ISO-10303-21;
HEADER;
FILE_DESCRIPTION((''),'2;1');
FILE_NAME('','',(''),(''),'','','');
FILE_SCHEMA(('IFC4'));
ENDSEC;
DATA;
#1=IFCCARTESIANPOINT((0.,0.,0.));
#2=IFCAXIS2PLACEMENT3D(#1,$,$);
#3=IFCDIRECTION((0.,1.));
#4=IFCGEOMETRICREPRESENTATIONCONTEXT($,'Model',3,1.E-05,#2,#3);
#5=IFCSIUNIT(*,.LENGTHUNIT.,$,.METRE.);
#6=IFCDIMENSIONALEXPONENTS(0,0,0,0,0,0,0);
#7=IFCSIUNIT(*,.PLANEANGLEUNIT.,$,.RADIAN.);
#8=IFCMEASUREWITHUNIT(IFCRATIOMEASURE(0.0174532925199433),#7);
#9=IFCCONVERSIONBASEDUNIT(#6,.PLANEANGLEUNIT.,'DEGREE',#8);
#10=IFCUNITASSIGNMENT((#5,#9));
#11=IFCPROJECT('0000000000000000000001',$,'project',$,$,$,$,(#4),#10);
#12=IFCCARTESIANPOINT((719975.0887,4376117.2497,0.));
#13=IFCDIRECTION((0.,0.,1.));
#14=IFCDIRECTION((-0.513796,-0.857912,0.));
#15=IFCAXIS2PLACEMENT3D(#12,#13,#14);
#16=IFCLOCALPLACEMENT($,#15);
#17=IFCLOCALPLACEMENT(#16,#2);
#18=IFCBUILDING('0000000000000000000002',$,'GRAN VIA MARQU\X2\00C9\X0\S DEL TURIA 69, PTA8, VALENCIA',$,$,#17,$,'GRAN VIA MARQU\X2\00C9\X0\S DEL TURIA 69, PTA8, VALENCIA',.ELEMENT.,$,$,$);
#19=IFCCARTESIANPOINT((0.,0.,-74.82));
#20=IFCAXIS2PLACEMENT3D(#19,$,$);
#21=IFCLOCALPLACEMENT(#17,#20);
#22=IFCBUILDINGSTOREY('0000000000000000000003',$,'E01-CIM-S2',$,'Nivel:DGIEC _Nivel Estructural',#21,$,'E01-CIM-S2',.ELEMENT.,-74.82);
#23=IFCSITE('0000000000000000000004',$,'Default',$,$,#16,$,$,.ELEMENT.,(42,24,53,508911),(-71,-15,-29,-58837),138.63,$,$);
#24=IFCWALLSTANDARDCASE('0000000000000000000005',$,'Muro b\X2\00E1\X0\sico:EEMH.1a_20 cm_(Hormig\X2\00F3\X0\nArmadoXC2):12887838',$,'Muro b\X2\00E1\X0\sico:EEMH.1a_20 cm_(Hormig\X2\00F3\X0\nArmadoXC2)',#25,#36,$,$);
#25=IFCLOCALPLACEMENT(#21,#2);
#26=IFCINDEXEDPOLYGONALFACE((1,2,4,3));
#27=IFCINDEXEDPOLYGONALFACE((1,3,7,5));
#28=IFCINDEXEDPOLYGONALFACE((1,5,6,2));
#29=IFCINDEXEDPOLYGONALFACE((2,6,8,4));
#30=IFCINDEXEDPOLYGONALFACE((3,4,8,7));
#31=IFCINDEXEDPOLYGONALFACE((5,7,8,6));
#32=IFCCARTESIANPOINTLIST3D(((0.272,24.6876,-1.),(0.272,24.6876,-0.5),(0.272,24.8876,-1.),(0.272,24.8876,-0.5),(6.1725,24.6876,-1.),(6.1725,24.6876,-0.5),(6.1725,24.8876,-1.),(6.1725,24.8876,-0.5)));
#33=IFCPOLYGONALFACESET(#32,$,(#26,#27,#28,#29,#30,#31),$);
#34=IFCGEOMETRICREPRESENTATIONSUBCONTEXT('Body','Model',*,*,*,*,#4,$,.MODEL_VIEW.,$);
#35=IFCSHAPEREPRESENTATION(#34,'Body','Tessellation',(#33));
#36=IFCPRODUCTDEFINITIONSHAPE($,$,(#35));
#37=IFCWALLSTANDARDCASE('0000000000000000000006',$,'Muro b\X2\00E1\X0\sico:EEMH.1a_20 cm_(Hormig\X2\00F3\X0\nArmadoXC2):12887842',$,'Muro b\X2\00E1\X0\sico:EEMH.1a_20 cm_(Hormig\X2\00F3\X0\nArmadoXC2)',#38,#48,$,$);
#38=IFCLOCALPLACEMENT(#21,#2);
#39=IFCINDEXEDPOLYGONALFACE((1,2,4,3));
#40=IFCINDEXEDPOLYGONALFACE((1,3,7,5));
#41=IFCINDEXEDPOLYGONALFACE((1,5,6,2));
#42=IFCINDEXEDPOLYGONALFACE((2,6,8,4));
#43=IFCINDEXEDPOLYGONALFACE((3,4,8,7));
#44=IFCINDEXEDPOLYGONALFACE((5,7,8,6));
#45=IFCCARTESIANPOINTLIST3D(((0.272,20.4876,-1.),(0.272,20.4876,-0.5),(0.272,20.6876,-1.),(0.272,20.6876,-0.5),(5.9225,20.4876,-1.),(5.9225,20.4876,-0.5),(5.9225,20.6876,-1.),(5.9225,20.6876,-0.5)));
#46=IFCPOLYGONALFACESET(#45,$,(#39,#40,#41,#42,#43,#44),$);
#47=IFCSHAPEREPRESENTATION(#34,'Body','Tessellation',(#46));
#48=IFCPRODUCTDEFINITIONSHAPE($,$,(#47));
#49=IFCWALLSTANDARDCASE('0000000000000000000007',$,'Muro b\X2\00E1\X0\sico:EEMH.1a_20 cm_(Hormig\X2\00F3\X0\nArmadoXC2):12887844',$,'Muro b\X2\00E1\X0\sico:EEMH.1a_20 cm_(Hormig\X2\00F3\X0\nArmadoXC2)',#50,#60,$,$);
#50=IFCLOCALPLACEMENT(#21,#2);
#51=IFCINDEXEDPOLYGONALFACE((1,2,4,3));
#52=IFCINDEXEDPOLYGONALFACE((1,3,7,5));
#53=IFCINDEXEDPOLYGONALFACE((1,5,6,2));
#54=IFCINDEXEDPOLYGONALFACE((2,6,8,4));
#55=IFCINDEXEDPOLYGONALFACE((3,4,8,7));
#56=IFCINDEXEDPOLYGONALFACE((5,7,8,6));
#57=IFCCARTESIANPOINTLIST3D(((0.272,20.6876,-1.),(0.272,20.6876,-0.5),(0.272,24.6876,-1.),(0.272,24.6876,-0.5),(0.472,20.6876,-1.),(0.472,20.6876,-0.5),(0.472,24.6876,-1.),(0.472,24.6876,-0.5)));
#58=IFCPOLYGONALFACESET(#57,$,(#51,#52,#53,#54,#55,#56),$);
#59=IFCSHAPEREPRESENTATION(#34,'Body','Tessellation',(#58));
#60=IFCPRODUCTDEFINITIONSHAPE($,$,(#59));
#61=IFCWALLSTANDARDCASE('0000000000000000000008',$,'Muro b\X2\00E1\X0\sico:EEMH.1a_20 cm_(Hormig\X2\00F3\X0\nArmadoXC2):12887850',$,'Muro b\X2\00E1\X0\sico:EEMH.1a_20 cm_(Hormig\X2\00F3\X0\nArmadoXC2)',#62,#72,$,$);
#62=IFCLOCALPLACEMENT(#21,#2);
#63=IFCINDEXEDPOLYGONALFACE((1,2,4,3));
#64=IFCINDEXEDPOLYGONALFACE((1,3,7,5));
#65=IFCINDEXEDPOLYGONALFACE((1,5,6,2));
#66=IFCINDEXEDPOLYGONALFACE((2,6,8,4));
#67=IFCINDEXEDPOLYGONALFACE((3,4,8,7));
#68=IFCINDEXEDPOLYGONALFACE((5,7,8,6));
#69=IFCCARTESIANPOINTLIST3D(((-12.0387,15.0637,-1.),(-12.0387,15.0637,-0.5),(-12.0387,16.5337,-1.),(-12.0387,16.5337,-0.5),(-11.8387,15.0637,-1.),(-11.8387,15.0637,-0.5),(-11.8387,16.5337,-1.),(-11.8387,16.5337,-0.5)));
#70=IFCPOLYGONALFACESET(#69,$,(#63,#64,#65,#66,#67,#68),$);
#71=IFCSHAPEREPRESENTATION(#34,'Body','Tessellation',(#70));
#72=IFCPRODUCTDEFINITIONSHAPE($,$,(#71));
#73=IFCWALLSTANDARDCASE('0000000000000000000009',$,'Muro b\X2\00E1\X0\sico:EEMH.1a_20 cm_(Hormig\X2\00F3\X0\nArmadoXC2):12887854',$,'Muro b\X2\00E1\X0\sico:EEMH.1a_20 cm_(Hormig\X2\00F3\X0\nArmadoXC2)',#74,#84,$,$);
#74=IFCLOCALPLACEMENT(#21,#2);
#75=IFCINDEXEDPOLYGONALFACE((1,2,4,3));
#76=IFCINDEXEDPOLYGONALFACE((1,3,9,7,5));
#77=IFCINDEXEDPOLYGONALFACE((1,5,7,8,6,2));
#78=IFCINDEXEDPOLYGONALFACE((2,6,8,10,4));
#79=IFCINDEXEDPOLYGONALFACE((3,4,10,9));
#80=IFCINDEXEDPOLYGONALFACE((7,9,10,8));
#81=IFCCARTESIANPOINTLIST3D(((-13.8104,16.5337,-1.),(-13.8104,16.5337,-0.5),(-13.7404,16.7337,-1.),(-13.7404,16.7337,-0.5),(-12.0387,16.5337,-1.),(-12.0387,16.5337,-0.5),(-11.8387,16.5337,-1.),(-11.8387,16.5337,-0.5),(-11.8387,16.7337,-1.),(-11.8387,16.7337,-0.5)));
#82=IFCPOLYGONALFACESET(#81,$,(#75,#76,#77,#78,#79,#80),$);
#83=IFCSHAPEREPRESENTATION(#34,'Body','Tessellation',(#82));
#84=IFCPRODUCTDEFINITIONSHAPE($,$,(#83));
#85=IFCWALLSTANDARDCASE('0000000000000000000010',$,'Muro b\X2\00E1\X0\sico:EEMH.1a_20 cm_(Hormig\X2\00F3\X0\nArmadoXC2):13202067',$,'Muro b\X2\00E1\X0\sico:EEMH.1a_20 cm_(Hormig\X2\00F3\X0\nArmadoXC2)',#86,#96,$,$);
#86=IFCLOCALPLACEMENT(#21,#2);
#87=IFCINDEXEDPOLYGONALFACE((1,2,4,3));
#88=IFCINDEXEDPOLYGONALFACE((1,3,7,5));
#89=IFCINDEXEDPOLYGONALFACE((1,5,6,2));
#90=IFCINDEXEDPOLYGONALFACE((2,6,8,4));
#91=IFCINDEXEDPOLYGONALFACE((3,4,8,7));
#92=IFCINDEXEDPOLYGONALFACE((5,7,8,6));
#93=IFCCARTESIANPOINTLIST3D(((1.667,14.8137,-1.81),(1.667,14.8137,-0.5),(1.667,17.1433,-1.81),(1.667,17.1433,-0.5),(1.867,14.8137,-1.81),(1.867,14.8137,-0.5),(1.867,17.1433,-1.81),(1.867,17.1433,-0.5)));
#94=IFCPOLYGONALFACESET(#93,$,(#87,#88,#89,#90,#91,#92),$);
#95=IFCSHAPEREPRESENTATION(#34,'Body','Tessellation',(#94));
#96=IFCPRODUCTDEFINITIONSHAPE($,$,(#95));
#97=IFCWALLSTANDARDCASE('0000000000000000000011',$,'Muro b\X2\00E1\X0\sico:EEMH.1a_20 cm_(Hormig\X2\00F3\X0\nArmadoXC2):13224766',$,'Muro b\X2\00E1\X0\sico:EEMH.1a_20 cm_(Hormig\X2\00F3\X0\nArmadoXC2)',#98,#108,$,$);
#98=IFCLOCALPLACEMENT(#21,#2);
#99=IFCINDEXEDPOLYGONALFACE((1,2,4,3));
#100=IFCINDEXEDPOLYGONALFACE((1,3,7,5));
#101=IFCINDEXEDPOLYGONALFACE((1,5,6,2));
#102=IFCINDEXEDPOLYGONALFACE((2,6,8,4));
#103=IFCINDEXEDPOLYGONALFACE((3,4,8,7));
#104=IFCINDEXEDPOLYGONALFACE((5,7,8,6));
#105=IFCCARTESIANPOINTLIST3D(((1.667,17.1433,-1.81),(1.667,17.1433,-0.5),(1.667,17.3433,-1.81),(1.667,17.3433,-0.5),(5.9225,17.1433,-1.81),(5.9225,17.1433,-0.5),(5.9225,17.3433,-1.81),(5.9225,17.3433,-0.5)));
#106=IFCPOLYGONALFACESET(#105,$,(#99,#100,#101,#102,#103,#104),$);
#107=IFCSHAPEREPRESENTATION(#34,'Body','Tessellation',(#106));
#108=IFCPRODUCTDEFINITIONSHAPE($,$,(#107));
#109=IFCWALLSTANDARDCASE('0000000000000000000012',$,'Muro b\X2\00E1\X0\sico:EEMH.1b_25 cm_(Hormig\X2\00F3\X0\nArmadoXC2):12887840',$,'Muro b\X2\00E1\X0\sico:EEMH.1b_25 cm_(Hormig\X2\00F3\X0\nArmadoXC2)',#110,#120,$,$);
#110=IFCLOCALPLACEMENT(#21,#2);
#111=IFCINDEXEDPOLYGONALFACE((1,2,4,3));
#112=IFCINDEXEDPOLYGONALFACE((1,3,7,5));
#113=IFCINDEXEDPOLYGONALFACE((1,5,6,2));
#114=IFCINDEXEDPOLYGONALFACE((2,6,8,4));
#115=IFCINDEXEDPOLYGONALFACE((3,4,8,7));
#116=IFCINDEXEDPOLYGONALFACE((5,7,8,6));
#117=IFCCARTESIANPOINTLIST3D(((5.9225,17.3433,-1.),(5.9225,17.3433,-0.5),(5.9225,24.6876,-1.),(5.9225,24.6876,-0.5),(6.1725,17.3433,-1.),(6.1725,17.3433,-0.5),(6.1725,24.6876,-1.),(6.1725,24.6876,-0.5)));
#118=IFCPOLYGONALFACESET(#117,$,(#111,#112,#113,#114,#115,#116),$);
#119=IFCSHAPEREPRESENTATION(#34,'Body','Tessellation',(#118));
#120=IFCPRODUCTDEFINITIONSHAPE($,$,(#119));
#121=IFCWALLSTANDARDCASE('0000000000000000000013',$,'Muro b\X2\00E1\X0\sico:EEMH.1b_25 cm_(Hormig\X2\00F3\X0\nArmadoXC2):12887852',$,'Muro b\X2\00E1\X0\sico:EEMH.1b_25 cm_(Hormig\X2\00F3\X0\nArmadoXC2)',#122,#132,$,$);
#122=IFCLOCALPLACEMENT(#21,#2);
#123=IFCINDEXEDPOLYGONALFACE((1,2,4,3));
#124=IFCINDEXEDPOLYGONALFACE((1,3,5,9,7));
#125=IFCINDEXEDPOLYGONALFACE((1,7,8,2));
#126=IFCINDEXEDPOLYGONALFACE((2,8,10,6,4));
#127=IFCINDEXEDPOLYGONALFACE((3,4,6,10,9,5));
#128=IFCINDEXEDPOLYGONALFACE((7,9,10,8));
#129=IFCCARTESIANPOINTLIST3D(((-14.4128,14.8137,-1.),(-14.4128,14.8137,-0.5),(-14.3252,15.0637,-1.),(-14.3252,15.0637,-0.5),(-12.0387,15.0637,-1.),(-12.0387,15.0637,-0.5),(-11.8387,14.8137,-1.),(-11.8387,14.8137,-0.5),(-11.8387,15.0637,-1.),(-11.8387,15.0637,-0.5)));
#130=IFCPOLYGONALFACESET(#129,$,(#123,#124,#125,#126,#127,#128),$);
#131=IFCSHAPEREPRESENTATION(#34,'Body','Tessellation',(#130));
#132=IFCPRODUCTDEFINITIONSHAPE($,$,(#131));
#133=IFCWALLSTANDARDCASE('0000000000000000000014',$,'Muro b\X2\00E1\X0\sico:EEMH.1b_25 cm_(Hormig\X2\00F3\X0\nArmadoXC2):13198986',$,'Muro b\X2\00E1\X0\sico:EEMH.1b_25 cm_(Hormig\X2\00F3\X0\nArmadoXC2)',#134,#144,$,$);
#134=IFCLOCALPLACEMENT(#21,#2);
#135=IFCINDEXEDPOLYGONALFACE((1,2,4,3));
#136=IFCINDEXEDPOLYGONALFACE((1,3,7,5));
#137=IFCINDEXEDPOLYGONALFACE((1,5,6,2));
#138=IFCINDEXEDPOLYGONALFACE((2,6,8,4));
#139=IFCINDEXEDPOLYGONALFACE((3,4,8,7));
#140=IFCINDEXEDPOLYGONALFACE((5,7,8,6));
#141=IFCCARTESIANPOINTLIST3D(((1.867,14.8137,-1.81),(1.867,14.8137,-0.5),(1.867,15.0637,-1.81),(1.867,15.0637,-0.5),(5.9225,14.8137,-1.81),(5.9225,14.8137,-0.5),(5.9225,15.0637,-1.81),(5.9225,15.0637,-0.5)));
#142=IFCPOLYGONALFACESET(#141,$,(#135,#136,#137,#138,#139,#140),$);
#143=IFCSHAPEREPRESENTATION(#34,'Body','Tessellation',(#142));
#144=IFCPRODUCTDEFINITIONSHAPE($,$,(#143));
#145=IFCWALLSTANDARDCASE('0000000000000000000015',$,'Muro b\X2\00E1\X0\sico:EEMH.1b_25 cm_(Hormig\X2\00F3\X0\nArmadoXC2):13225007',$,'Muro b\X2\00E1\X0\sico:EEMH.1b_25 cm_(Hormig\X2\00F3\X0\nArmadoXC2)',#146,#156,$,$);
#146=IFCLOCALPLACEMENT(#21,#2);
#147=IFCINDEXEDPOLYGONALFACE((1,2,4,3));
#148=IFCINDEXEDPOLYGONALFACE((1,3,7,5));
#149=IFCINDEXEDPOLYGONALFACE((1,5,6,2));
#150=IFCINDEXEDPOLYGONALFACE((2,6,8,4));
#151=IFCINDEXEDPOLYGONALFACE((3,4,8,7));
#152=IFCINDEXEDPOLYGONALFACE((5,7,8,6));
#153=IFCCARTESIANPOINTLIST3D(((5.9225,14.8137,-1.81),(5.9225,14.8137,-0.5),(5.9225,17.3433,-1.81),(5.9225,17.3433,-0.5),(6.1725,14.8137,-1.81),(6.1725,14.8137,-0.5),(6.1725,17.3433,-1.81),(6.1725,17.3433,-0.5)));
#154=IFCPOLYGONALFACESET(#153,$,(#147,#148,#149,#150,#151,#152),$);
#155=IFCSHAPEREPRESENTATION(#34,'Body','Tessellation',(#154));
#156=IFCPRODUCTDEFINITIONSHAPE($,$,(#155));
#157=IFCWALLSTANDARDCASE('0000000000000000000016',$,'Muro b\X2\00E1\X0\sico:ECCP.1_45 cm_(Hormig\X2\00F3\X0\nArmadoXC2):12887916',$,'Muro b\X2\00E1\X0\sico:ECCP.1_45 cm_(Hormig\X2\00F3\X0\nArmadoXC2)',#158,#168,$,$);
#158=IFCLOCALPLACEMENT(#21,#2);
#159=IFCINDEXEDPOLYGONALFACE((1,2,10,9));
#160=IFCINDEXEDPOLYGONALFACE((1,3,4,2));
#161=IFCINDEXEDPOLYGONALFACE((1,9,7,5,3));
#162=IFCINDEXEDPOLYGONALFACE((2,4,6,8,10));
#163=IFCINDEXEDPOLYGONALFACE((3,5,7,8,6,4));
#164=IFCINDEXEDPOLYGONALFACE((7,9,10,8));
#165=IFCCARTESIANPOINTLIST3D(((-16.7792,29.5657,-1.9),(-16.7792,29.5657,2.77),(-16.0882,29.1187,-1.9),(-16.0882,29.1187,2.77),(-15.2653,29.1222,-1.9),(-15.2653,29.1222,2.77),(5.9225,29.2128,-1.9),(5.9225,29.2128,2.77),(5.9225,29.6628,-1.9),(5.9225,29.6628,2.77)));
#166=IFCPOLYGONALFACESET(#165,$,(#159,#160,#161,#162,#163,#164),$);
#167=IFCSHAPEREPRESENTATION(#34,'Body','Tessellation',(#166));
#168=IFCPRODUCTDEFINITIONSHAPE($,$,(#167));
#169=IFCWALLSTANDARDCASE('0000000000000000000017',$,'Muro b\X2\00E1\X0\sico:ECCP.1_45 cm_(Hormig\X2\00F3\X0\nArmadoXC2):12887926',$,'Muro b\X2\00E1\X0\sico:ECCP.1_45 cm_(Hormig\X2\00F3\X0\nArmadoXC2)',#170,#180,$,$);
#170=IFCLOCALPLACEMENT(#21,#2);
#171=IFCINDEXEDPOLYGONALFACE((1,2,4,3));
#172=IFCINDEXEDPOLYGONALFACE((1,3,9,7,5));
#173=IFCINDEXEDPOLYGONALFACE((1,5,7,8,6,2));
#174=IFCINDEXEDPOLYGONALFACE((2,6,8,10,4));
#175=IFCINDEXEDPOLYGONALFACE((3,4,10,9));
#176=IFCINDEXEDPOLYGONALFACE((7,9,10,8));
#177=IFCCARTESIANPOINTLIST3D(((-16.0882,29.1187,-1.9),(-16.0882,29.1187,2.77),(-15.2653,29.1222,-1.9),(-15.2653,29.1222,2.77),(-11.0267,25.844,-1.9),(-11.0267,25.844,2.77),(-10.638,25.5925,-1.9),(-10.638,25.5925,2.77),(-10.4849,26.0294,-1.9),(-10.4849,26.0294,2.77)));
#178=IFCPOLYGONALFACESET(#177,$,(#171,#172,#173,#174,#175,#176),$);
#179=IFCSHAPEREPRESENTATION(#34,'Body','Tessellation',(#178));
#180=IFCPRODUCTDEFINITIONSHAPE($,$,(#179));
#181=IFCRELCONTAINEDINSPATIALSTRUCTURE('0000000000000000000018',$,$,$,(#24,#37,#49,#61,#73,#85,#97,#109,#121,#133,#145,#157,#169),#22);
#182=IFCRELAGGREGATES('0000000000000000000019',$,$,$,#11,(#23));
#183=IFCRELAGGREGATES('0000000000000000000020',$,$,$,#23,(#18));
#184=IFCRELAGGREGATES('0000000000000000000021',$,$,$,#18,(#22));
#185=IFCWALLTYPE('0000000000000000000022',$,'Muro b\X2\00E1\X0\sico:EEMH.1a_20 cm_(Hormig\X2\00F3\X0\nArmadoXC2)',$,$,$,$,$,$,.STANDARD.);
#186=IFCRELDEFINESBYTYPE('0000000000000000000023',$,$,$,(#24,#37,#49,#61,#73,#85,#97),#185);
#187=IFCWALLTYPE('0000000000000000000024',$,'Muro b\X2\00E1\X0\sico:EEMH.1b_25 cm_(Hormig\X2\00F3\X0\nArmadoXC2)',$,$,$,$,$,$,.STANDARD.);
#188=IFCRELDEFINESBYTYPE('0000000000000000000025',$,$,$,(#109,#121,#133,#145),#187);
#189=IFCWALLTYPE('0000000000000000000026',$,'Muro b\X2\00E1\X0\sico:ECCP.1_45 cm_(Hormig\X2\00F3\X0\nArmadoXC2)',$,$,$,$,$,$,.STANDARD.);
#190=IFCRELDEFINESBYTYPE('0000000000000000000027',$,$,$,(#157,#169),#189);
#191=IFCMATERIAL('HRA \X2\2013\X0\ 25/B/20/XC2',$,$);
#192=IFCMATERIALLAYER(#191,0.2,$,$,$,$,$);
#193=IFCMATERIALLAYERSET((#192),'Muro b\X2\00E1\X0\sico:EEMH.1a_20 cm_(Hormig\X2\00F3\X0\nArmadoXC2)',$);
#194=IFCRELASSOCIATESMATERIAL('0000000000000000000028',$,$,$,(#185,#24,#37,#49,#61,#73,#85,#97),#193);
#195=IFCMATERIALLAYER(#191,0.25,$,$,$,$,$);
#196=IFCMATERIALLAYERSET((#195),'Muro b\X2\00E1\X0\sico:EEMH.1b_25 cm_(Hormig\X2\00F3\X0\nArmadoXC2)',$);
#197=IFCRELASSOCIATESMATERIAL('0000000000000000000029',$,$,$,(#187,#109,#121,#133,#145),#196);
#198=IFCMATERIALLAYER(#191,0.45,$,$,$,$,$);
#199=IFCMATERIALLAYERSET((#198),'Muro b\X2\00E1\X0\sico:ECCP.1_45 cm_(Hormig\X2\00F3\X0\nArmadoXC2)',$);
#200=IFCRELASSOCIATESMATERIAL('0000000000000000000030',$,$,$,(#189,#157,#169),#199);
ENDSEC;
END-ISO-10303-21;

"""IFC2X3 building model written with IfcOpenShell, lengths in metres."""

from ifc_helpers import new_model, entity, si_unit, converted_unit, direction, frame, frame_2d, origin, place, context, subcontext, project, spatial, polyline, rectangle, outline, extrude, clip, bounded_halfspace, material, layer, layer_set, layer_usage, type_object, element, save


model = new_model("IFC2X3")

# Units and contexts
model_context = context("Model", 3, precision=1e-05, world=origin(), true_north=direction((0.0, 1.0)))
body_context = subcontext(model_context, "Body", "Model", "MODEL_VIEW")
ifc_project = project(units=[si_unit("LENGTHUNIT", "METRE"), converted_unit("PLANEANGLEUNIT", "DEGREE", entity("IfcRatioMeasure", 0.0174532925199433), si_unit("PLANEANGLEUNIT", "RADIAN"), dimensions=[0, 0, 0, 0, 0, 0, 0])], contexts=[model_context])

# Site, building, storey
site_placement = place(None, frame((719975.0887, 4376117.2497, 0.0), z_axis=(0.0, 0.0, 1.0), x_axis=(-0.513796, -0.857912, 0.0)))
site = spatial("IfcSite", under=ifc_project, at=site_placement, Name="Default", CompositionType="ELEMENT", RefLatitude=(42, 24, 53, 508911), RefLongitude=(-71, -15, -29, -58837), RefElevation=138.63)
building_placement = place(site_placement, origin())
building = spatial("IfcBuilding", under=site, at=building_placement, Name="GRAN VIA MARQUÉS DEL TURIA 69, PTA8, VALENCIA", LongName="GRAN VIA MARQUÉS DEL TURIA 69, PTA8, VALENCIA", CompositionType="ELEMENT")
storey_placement = place(building_placement, frame((0.0, 0.0, -74.82)))
storey = spatial("IfcBuildingStorey", under=building, at=storey_placement, Name="E01-CIM-S2", ObjectType="Nivel:DGIEC _Nivel Estructural", LongName="E01-CIM-S2", CompositionType="ELEMENT", Elevation=-74.82)

# Shared definitions
ifc_material_1 = material(Name="HRA – 25/B/20/XC2")

# Walls
ifc_layer_1 = layer(ifc_material_1, 0.2)
ifc_layer_set_1 = layer_set([ifc_layer_1], Name="Muro básico:EEMH.1a_20 cm_(HormigónArmadoXC2)")
ifc_layer_usage_1 = layer_usage(ifc_layer_set_1, "AXIS2", "NEGATIVE", 0.1)
wall_type_1 = type_object("IfcWallType", Name="Muro básico:EEMH.1a_20 cm_(HormigónArmadoXC2)", PredefinedType="STANDARD", material=ifc_layer_set_1)
wall_1_placement = place(storey_placement, frame((0.272, 24.7876, -1.0)))
element("IfcWallStandardCase", 1, at=wall_1_placement, inside=storey, type_object=wall_type_1, material=ifc_layer_usage_1, Name="Muro básico:EEMH.1a_20 cm_(HormigónArmadoXC2):12887838", ObjectType="Muro básico:EEMH.1a_20 cm_(HormigónArmadoXC2)", context=body_context, shape_type="SweptSolid", body=[
    extrude(rectangle(XDim=5.9006, YDim=0.2, at=frame_2d((2.9503, 0.0), x_axis=(-1.0, 0.0))), origin(), (0.0, 0.0, 1.0), 0.5),
])
ifc_layer_usage_2 = layer_usage(ifc_layer_set_1, "AXIS2", "NEGATIVE", 0.1)
wall_2_placement = place(storey_placement, frame((5.9225, 20.5876, -1.0), z_axis=(0.0, 0.0, 1.0), x_axis=(-1.0, 0.0, 0.0)))
element("IfcWallStandardCase", 2, at=wall_2_placement, inside=storey, type_object=wall_type_1, material=ifc_layer_usage_2, Name="Muro básico:EEMH.1a_20 cm_(HormigónArmadoXC2):12887842", ObjectType="Muro básico:EEMH.1a_20 cm_(HormigónArmadoXC2)", context=body_context, shape_type="Clipping", body=[
    clip(extrude(rectangle(XDim=5.6506, YDim=0.2, at=frame_2d((2.8253, 0.0), x_axis=(-1.0, 0.0))), origin(), (0.0, 0.0, 1.0), 0.5), bounded_halfspace(frame((0.0, -0.1, 0.5), z_axis=(0.0, 0.0, -1.0), x_axis=(-0.330527, -0.943797, 0.0)), True, frame((0.0, -0.1, 0.5)), polyline([(0.0, 0.0), (5.4506, 0.0), (5.6506, 0.0), (5.6506, 0.2), (0.0, 0.2), (0.0, 0.0)]))),
])
ifc_layer_usage_3 = layer_usage(ifc_layer_set_1, "AXIS2", "NEGATIVE", 0.1)
wall_3_placement = place(storey_placement, frame((0.372, 20.6876, -1.0), z_axis=(0.0, 0.0, 1.0), x_axis=(0.0, 1.0, 0.0)))
element("IfcWallStandardCase", 3, at=wall_3_placement, inside=storey, type_object=wall_type_1, material=ifc_layer_usage_3, Name="Muro básico:EEMH.1a_20 cm_(HormigónArmadoXC2):12887844", ObjectType="Muro básico:EEMH.1a_20 cm_(HormigónArmadoXC2)", context=body_context, shape_type="Clipping", body=[
    clip(extrude(rectangle(XDim=4.0, YDim=0.2, at=frame_2d((2.0, 0.0), x_axis=(-1.0, 0.0))), origin(), (0.0, 0.0, 1.0), 0.5), bounded_halfspace(frame((0.0, -0.1, 0.5), z_axis=(0.0, 0.0, -1.0), x_axis=(0.943797, -0.330527, 0.0)), True, frame((0.0, -0.1, 0.5)), polyline([(0.0, 0.0), (4.0, 0.0), (4.0, 0.2), (0.0, 0.2), (0.0, 0.0)]))),
])
ifc_layer_usage_4 = layer_usage(ifc_layer_set_1, "AXIS2", "NEGATIVE", 0.1)
wall_4_placement = place(storey_placement, frame((-11.9387, 15.0637, -1.0), z_axis=(0.0, 0.0, 1.0), x_axis=(0.0, 1.0, 0.0)))
element("IfcWallStandardCase", 4, at=wall_4_placement, inside=storey, type_object=wall_type_1, material=ifc_layer_usage_4, Name="Muro básico:EEMH.1a_20 cm_(HormigónArmadoXC2):12887850", ObjectType="Muro básico:EEMH.1a_20 cm_(HormigónArmadoXC2)", context=body_context, shape_type="SweptSolid", body=[
    extrude(rectangle(XDim=1.47, YDim=0.2, at=frame_2d((0.735, 0.0), x_axis=(-1.0, 0.0))), origin(), (0.0, 0.0, 1.0), 0.5),
])
ifc_layer_usage_5 = layer_usage(ifc_layer_set_1, "AXIS2", "NEGATIVE", 0.1)
wall_5_placement = place(storey_placement, frame((-13.8104, 16.6337, -1.0)))
element("IfcWallStandardCase", 5, at=wall_5_placement, inside=storey, type_object=wall_type_1, material=ifc_layer_usage_5, Name="Muro básico:EEMH.1a_20 cm_(HormigónArmadoXC2):12887854", ObjectType="Muro básico:EEMH.1a_20 cm_(HormigónArmadoXC2)", context=body_context, shape_type="SweptSolid", body=[
    extrude(outline(polyline([(1.9717, -0.1), (1.9717, 0.1), (0.07, 0.1), (0.0, -0.1), (1.7717, -0.1), (1.9717, -0.1)])), origin(), (0.0, 0.0, 1.0), 0.5),
])
ifc_layer_usage_6 = layer_usage(ifc_layer_set_1, "AXIS2", "NEGATIVE", 0.1)
wall_6_placement = place(storey_placement, frame((1.767, 14.8137, -1.81), z_axis=(0.0, 0.0, 1.0), x_axis=(0.0, 1.0, 0.0)))
element("IfcWallStandardCase", 6, at=wall_6_placement, inside=storey, type_object=wall_type_1, material=ifc_layer_usage_6, Name="Muro básico:EEMH.1a_20 cm_(HormigónArmadoXC2):13202067", ObjectType="Muro básico:EEMH.1a_20 cm_(HormigónArmadoXC2)", context=body_context, shape_type="SweptSolid", body=[
    extrude(rectangle(XDim=2.3296, YDim=0.2, at=frame_2d((1.1648, 0.0), x_axis=(-1.0, 0.0))), origin(), (0.0, 0.0, 1.0), 1.31),
])
ifc_layer_usage_7 = layer_usage(ifc_layer_set_1, "AXIS2", "NEGATIVE", 0.1)
wall_7_placement = place(storey_placement, frame((1.667, 17.2433, -1.81)))
element("IfcWallStandardCase", 7, at=wall_7_placement, inside=storey, type_object=wall_type_1, material=ifc_layer_usage_7, Name="Muro básico:EEMH.1a_20 cm_(HormigónArmadoXC2):13224766", ObjectType="Muro básico:EEMH.1a_20 cm_(HormigónArmadoXC2)", context=body_context, shape_type="SweptSolid", body=[
    extrude(rectangle(XDim=4.2556, YDim=0.2, at=frame_2d((2.1278, 0.0), x_axis=(-1.0, 0.0))), origin(), (0.0, 0.0, 1.0), 1.31),
])
ifc_layer_2 = layer(ifc_material_1, 0.25)
ifc_layer_set_2 = layer_set([ifc_layer_2], Name="Muro básico:EEMH.1b_25 cm_(HormigónArmadoXC2)")
ifc_layer_usage_8 = layer_usage(ifc_layer_set_2, "AXIS2", "NEGATIVE", 0.125)
wall_type_2 = type_object("IfcWallType", Name="Muro básico:EEMH.1b_25 cm_(HormigónArmadoXC2)", PredefinedType="STANDARD", material=ifc_layer_set_2)
wall_8_placement = place(storey_placement, frame((6.0475, 24.6876, -1.0), z_axis=(0.0, 0.0, 1.0), x_axis=(0.0, -1.0, 0.0)))
element("IfcWallStandardCase", 8, at=wall_8_placement, inside=storey, type_object=wall_type_2, material=ifc_layer_usage_8, Name="Muro básico:EEMH.1b_25 cm_(HormigónArmadoXC2):12887840", ObjectType="Muro básico:EEMH.1b_25 cm_(HormigónArmadoXC2)", context=body_context, shape_type="Clipping", body=[
    clip(extrude(rectangle(XDim=7.3442, YDim=0.25, at=frame_2d((3.6721, 0.0), x_axis=(-1.0, 0.0))), origin(), (0.0, 0.0, 1.0), 0.5), bounded_halfspace(frame((0.0, -0.125, 0.5), z_axis=(0.0, 0.0, -1.0), x_axis=(-0.943797, 0.330527, 0.0)), True, frame((0.0, -0.125, 0.5)), polyline([(0.0, 0.0), (4.0, 0.0), (4.2, 0.0), (7.3442, 0.0), (7.3442, 0.25), (0.0, 0.25), (0.0, 0.0)]))),
])
ifc_layer_usage_9 = layer_usage(ifc_layer_set_2, "AXIS2", "NEGATIVE", 0.125)
wall_9_placement = place(storey_placement, frame((-11.8387, 14.9387, -1.0), z_axis=(0.0, 0.0, 1.0), x_axis=(-1.0, 0.0, 0.0)))
element("IfcWallStandardCase", 9, at=wall_9_placement, inside=storey, type_object=wall_type_2, material=ifc_layer_usage_9, Name="Muro básico:EEMH.1b_25 cm_(HormigónArmadoXC2):12887852", ObjectType="Muro básico:EEMH.1b_25 cm_(HormigónArmadoXC2)", context=body_context, shape_type="SweptSolid", body=[
    extrude(outline(polyline([(2.4865, -0.125), (2.574, 0.125), (0.0, 0.125), (0.0, -0.125), (0.2, -0.125), (2.4865, -0.125)])), origin(), (0.0, 0.0, 1.0), 0.5),
])
ifc_layer_usage_10 = layer_usage(ifc_layer_set_2, "AXIS2", "NEGATIVE", 0.125)
wall_10_placement = place(storey_placement, frame((5.9225, 14.9387, -1.81), z_axis=(0.0, 0.0, 1.0), x_axis=(-1.0, 0.0, 0.0)))
element("IfcWallStandardCase", 10, at=wall_10_placement, inside=storey, type_object=wall_type_2, material=ifc_layer_usage_10, Name="Muro básico:EEMH.1b_25 cm_(HormigónArmadoXC2):13198986", ObjectType="Muro básico:EEMH.1b_25 cm_(HormigónArmadoXC2)", context=body_context, shape_type="SweptSolid", body=[
    extrude(rectangle(XDim=4.0556, YDim=0.25, at=frame_2d((2.0278, 0.0), x_axis=(-1.0, 0.0))), origin(), (0.0, 0.0, 1.0), 1.31),
])
ifc_layer_usage_11 = layer_usage(ifc_layer_set_2, "AXIS2", "NEGATIVE", 0.125)
wall_11_placement = place(storey_placement, frame((6.0475, 17.3433, -1.81), z_axis=(0.0, 0.0, 1.0), x_axis=(0.0, -1.0, 0.0)))
element("IfcWallStandardCase", 11, at=wall_11_placement, inside=storey, type_object=wall_type_2, material=ifc_layer_usage_11, Name="Muro básico:EEMH.1b_25 cm_(HormigónArmadoXC2):13225007", ObjectType="Muro básico:EEMH.1b_25 cm_(HormigónArmadoXC2)", context=body_context, shape_type="Clipping", body=[
    clip(extrude(rectangle(XDim=2.5296, YDim=0.25, at=frame_2d((1.2648, 0.0), x_axis=(-1.0, 0.0))), origin(), (0.0, 0.0, 1.0), 1.31), bounded_halfspace(frame((0.0, -0.125, 1.31), z_axis=(0.0, 0.0, -1.0), x_axis=(-0.943797, 0.330527, 0.0)), True, frame((0.0, -0.125, 1.31)), polyline([(0.0, 0.0), (0.2, 0.0), (2.2796, 0.0), (2.5296, 0.0), (2.5296, 0.25), (0.0, 0.25), (0.0, 0.0)]))),
])
ifc_layer_3 = layer(ifc_material_1, 0.45)
ifc_layer_set_3 = layer_set([ifc_layer_3], Name="Muro básico:ECCP.1_45 cm_(HormigónArmadoXC2)")
ifc_layer_usage_12 = layer_usage(ifc_layer_set_3, "AXIS2", "NEGATIVE", 0.225)
wall_type_3 = type_object("IfcWallType", Name="Muro básico:ECCP.1_45 cm_(HormigónArmadoXC2)", PredefinedType="STANDARD", material=ifc_layer_set_3)
wall_12_placement = place(storey_placement, frame((-16.7783, 29.3407, -1.9), z_axis=(0.0, 0.0, 1.0), x_axis=(0.999991, 0.004278, 0.0)))
element("IfcWallStandardCase", 12, at=wall_12_placement, inside=storey, type_object=wall_type_3, material=ifc_layer_usage_12, Name="Muro básico:ECCP.1_45 cm_(HormigónArmadoXC2):12887916", ObjectType="Muro básico:ECCP.1_45 cm_(HormigónArmadoXC2)", context=body_context, shape_type="SweptSolid", body=[
    extrude(outline(polyline([(22.7, -0.225), (22.702, 0.225), (0.0, 0.225), (0.6891, -0.225), (1.5121, -0.225), (22.7, -0.225)])), origin(), (0.0, 0.0, 1.0), 4.67),
])
ifc_layer_usage_13 = layer_usage(ifc_layer_set_3, "AXIS2", "NEGATIVE", 0.225)
wall_13_placement = place(storey_placement, frame((-10.5157, 25.7814, -1.9), z_axis=(0.0, 0.0, 1.0), x_axis=(-0.839602, 0.543202, 0.0)))
element("IfcWallStandardCase", 13, at=wall_13_placement, inside=storey, type_object=wall_type_3, material=ifc_layer_usage_13, Name="Muro básico:ECCP.1_45 cm_(HormigónArmadoXC2):12887926", ObjectType="Muro básico:ECCP.1_45 cm_(HormigónArmadoXC2)", context=body_context, shape_type="SweptSolid", body=[
    extrude(outline(polyline([(5.8024, -0.225), (6.4915, 0.225), (0.463, 0.225), (0.0, 0.225), (0.1089, -0.225), (5.8024, -0.225)])), origin(), (0.0, 0.0, 1.0), 4.67),
])

save(model, "model.ifc")
